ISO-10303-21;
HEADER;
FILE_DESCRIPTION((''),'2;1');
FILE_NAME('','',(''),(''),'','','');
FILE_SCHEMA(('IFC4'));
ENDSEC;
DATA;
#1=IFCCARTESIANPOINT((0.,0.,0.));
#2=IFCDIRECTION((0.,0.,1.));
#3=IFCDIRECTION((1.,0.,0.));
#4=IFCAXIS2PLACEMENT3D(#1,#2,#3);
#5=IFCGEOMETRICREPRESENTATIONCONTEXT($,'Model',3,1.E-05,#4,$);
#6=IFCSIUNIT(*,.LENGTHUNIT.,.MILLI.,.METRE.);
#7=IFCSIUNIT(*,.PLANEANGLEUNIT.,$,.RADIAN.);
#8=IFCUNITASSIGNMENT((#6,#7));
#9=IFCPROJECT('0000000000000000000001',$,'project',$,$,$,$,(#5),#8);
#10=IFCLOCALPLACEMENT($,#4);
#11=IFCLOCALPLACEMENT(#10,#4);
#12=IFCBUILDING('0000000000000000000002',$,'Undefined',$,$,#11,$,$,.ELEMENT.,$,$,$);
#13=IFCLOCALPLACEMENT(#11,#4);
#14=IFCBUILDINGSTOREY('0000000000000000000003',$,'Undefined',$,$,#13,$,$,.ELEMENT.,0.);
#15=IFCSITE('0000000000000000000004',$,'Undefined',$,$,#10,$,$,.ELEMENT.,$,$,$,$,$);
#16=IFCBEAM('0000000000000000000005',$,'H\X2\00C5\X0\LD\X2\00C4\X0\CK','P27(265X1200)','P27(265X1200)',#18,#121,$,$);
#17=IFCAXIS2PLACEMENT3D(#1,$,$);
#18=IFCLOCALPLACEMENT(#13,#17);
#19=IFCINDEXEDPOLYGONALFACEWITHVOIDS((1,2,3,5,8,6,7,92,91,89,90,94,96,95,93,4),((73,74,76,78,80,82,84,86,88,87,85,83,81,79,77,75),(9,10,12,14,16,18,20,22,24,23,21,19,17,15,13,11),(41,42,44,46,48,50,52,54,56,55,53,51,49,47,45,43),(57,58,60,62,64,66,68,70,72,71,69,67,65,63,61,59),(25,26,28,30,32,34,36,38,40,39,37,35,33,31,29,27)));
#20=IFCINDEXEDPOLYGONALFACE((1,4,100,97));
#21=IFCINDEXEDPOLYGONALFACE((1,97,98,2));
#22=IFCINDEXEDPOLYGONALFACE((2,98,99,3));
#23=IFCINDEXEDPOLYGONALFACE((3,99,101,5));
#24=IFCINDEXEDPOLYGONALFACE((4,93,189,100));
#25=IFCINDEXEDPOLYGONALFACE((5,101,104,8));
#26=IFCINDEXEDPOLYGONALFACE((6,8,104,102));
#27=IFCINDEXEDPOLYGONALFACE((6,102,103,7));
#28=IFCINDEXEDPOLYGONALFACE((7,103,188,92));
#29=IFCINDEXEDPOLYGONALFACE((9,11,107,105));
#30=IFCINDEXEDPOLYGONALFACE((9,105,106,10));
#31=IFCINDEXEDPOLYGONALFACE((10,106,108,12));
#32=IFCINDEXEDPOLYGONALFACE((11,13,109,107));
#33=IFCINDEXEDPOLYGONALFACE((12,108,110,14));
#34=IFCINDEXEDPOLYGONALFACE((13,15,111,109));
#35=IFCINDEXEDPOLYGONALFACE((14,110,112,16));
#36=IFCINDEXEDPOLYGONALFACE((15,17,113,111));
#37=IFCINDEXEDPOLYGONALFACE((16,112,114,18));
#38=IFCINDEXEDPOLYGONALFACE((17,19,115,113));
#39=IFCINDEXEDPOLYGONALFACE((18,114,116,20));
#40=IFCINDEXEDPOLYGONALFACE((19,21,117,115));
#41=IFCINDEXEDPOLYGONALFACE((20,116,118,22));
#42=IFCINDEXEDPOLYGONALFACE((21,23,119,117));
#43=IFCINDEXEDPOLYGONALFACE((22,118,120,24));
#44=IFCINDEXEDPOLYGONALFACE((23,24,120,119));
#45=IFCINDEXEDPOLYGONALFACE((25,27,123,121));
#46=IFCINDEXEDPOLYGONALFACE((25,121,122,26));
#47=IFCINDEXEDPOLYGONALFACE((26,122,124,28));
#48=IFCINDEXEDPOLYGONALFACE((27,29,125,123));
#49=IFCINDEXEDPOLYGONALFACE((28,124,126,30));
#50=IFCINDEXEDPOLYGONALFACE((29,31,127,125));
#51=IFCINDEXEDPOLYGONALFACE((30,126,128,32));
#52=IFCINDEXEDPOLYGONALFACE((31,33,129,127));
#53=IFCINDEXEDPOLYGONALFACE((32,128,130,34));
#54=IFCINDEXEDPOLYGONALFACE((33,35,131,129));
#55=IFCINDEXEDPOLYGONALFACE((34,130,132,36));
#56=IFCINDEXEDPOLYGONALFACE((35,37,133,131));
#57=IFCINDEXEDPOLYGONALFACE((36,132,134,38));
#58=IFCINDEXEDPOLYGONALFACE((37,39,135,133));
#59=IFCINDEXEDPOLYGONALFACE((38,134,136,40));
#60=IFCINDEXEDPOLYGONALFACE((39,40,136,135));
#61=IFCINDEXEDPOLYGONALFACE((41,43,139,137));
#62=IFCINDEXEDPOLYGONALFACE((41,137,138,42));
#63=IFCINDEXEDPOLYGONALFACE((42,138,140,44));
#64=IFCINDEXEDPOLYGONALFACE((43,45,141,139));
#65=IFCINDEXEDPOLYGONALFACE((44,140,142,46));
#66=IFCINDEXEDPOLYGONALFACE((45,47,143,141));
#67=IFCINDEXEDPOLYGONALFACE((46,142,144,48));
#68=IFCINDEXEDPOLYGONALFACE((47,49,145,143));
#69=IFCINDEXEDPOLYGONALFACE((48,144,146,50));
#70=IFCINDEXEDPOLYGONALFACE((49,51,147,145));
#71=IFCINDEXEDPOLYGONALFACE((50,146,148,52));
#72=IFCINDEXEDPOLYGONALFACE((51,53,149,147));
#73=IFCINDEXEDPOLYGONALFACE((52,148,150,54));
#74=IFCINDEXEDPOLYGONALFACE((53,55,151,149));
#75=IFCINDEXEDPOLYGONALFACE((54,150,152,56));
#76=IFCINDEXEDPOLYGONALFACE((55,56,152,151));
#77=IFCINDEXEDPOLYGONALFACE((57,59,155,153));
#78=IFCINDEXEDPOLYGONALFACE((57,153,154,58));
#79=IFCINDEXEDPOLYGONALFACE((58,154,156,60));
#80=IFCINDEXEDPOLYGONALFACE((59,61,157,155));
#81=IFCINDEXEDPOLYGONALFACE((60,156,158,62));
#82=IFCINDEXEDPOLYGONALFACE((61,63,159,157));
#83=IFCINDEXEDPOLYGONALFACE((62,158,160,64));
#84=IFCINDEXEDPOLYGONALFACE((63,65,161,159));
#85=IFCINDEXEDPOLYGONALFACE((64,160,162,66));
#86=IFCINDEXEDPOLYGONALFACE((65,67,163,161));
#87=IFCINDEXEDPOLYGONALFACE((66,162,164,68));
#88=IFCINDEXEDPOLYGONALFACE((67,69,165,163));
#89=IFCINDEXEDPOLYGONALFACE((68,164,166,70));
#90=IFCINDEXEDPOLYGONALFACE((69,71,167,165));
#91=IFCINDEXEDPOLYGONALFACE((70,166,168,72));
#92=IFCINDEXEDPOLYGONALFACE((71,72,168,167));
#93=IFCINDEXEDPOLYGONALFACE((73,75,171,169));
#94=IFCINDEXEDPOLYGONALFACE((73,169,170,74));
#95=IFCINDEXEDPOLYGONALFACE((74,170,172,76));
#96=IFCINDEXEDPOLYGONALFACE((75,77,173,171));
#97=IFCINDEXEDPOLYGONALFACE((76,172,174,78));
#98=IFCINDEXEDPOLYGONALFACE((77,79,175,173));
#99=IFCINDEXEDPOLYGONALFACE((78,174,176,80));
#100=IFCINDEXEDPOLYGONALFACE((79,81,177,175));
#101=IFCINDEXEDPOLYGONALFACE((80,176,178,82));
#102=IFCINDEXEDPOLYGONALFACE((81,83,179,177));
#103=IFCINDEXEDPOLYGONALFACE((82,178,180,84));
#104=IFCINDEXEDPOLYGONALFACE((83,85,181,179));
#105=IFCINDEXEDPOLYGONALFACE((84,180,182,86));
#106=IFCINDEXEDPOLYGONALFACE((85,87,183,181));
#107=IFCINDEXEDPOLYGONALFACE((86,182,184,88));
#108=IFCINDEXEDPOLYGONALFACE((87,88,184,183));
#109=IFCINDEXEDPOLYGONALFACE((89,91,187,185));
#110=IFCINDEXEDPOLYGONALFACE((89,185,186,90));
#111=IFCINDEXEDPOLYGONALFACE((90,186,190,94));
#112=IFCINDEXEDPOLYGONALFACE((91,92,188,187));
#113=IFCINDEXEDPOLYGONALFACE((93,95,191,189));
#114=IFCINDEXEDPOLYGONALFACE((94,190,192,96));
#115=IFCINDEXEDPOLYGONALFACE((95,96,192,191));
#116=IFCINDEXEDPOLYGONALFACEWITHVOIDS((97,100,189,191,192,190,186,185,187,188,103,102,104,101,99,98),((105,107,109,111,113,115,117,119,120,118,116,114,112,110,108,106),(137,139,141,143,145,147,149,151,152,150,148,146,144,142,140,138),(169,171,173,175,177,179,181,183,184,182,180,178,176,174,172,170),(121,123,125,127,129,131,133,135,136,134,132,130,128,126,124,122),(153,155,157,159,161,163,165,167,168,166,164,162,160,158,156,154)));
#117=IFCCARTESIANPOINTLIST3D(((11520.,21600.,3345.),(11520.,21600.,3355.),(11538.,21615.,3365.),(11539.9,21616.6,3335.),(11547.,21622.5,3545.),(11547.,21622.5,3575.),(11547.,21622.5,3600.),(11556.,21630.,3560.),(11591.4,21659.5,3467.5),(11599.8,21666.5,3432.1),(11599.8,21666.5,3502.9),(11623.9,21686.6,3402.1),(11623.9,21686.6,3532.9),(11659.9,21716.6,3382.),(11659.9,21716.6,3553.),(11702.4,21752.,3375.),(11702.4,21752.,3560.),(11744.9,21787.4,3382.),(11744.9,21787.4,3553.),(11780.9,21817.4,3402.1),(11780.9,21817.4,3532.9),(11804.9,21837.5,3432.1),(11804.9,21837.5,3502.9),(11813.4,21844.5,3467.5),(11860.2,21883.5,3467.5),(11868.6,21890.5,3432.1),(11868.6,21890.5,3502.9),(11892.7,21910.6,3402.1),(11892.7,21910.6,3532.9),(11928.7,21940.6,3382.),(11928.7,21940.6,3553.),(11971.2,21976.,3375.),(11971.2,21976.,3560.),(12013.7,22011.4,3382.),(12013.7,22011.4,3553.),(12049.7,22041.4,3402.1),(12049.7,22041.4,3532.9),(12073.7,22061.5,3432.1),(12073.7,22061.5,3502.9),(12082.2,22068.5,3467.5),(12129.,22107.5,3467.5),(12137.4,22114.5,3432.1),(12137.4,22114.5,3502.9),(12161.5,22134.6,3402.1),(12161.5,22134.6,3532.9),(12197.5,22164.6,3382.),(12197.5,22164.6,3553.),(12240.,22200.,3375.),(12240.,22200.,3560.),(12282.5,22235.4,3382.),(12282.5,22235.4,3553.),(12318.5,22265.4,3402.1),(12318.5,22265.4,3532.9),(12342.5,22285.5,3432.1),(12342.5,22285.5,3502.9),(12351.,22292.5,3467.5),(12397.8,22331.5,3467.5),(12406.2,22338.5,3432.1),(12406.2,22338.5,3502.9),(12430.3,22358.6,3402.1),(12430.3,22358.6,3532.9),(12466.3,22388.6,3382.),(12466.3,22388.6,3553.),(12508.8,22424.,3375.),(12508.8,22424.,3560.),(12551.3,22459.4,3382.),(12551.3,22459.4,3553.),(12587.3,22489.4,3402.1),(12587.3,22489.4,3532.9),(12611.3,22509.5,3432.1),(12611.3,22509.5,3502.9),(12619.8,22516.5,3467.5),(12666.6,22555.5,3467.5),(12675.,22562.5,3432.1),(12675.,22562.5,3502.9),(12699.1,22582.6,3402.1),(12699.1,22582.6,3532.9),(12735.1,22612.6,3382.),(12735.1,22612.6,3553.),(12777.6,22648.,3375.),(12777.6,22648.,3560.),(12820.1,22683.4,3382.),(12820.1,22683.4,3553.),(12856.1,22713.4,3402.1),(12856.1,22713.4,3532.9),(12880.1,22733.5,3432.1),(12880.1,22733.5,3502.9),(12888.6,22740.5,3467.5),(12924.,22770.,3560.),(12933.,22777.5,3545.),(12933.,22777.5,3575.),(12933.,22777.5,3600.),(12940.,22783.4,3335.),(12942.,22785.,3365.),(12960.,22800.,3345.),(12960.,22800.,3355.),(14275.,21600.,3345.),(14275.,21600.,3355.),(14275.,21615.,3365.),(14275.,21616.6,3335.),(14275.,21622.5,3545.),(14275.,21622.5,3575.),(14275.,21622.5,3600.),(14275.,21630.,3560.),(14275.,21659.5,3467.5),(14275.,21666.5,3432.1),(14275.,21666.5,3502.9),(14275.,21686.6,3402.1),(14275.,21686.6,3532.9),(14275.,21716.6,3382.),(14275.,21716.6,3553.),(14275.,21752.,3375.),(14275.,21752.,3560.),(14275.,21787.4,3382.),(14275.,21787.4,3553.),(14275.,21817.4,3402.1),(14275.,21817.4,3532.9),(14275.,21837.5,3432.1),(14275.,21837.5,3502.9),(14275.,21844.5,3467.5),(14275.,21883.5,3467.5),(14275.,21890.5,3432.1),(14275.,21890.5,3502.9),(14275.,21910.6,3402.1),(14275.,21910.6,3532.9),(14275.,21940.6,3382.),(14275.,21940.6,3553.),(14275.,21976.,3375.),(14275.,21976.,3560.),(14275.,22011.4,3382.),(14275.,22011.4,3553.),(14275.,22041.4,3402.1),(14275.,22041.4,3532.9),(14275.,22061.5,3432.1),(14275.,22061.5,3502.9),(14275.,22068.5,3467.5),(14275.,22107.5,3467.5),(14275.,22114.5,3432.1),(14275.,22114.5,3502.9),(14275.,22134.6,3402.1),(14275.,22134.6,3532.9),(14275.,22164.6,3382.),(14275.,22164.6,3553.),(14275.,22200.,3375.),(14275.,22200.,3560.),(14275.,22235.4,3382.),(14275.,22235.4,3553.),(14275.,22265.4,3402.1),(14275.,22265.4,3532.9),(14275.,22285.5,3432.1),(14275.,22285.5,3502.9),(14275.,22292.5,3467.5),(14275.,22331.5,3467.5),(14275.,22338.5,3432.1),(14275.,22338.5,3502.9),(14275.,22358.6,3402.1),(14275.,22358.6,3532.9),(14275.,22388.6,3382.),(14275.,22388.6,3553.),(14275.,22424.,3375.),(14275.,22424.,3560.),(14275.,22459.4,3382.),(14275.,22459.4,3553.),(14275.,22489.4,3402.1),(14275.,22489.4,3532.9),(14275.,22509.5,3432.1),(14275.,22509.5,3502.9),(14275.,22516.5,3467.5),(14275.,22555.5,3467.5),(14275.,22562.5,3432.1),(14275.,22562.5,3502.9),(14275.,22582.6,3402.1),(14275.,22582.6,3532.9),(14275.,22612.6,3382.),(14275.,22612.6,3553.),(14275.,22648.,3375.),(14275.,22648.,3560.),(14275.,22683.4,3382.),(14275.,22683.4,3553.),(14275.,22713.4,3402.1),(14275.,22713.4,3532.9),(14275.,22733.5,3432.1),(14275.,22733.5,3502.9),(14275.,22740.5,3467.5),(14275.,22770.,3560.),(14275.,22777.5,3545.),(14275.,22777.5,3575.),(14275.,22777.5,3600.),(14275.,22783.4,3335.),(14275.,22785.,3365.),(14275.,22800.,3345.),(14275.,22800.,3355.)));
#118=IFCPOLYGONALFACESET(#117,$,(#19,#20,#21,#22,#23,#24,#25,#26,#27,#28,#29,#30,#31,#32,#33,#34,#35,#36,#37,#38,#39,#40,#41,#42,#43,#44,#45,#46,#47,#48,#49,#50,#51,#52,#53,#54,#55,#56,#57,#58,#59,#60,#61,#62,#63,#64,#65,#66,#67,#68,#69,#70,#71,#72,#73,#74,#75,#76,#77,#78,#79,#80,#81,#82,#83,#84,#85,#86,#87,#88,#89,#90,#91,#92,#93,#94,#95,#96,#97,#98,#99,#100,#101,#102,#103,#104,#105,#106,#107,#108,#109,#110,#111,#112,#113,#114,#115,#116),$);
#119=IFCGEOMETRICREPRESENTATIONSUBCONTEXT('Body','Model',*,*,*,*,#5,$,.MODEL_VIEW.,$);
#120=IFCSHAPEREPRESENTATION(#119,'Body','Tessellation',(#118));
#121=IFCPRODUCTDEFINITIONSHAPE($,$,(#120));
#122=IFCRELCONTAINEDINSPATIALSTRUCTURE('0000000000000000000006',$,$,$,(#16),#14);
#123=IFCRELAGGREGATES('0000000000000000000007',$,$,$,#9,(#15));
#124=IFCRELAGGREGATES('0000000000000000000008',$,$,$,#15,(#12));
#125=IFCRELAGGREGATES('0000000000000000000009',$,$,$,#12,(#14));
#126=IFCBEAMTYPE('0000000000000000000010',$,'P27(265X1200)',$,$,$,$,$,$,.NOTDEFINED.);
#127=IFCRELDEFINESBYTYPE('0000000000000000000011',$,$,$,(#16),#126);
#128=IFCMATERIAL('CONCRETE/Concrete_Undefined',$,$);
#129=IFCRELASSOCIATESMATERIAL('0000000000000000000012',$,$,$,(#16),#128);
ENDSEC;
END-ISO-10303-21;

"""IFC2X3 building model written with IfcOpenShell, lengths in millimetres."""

from ifc_helpers import new_model, si_unit, frame, origin_with_axes, place, context, subcontext, project, spatial, polyline, outline, extrude, clip, halfspace, material, type_object, element, save


model = new_model("IFC2X3")

# Units and contexts
model_context = context("Model", 3, precision=1e-05, world=origin_with_axes())
body_context = subcontext(model_context, "Body", "Model", "MODEL_VIEW")
ifc_project = project(units=[si_unit("LENGTHUNIT", "METRE", prefix="MILLI"), si_unit("PLANEANGLEUNIT", "RADIAN")], contexts=[model_context])

# Site, building, storey
site_placement = place(None, origin_with_axes())
site = spatial("IfcSite", under=ifc_project, at=site_placement, Name="Undefined", CompositionType="ELEMENT")
building_placement = place(site_placement, origin_with_axes())
building = spatial("IfcBuilding", under=site, at=building_placement, Name="Undefined", CompositionType="ELEMENT")
storey_placement = place(building_placement, origin_with_axes())
storey = spatial("IfcBuildingStorey", under=building, at=storey_placement, Name="Undefined", CompositionType="ELEMENT", Elevation=0.0)

# Beam
ifc_material_1 = material(Name="CONCRETE/Concrete_Undefined")
beam_type_1 = type_object("IfcBeamType", Name="P27(265X1200)", PredefinedType="NOTDEFINED")
beam_1_placement = place(storey_placement, frame((11520.0, 22200.0, 3467.5), z_axis=(0.0, 0.0, 1.0), x_axis=(1.0, 0.0, 0.0)))
element("IfcBeam", 1, at=beam_1_placement, inside=storey, type_object=beam_type_1, material=ifc_material_1, Name="HÅLDÄCK", Description="P27(265X1200)", ObjectType="P27(265X1200)", context=body_context, shape_type="Clipping", body=[
    clip(extrude(outline(polyline([(-583.4, -132.5), (-600.0, -122.5), (-600.0, -112.5), (-585.0, -102.5), (-577.5, 77.5), (-570.0, 92.5), (-577.5, 107.5), (-577.5, 132.5), (577.5, 132.5), (577.5, 107.5), (570.0, 92.5), (577.5, 77.5), (585.0, -102.5), (600.0, -112.5), (600.0, -122.5), (583.4, -132.5), (-583.4, -132.5)]), holes=[polyline([(-513.4, 65.4), (-533.5, 35.4), (-540.5, 0.0), (-533.5, -35.4), (-513.4, -65.4), (-483.4, -85.5), (-448.0, -92.5), (-412.6, -85.5), (-382.6, -65.4), (-362.5, -35.4), (-355.5, 0.0), (-362.5, 35.4), (-382.6, 65.4), (-412.6, 85.5), (-448.0, 92.5), (-483.4, 85.5), (-513.4, 65.4)]), polyline([(-289.4, 65.4), (-309.5, 35.4), (-316.5, 0.0), (-309.5, -35.4), (-289.4, -65.4), (-259.4, -85.5), (-224.0, -92.5), (-188.6, -85.5), (-158.6, -65.4), (-138.5, -35.4), (-131.5, 0.0), (-138.5, 35.4), (-158.6, 65.4), (-188.6, 85.5), (-224.0, 92.5), (-259.4, 85.5), (-289.4, 65.4)]), polyline([(-65.4, 65.4), (-85.5, 35.4), (-92.5, 0.0), (-85.5, -35.4), (-65.4, -65.4), (-35.4, -85.5), (0.0, -92.5), (35.4, -85.5), (65.4, -65.4), (85.5, -35.4), (92.5, 0.0), (85.5, 35.4), (65.4, 65.4), (35.4, 85.5), (0.0, 92.5), (-35.4, 85.5), (-65.4, 65.4)]), polyline([(158.6, 65.4), (138.5, 35.4), (131.5, 0.0), (138.5, -35.4), (158.6, -65.4), (188.6, -85.5), (224.0, -92.5), (259.4, -85.5), (289.4, -65.4), (309.5, -35.4), (316.5, 0.0), (309.5, 35.4), (289.4, 65.4), (259.4, 85.5), (224.0, 92.5), (188.6, 85.5), (158.6, 65.4)]), polyline([(382.6, 65.4), (362.5, 35.4), (355.5, 0.0), (362.5, -35.4), (382.6, -65.4), (412.6, -85.5), (448.0, -92.5), (483.4, -85.5), (513.4, -65.4), (533.5, -35.4), (540.5, 0.0), (533.5, 35.4), (513.4, 65.4), (483.4, 85.5), (448.0, 92.5), (412.6, 85.5), (382.6, 65.4)])]), frame((2755.0, 0.0, 0.0), z_axis=(-1.0, 0.0, 0.0), x_axis=(0.0, -1.0, 0.0)), (0.0, 0.0, 1.0), 2755.0), halfspace(frame((1440.0, 600.0, -132.5), z_axis=(-0.640184, 0.768221, 0.0), x_axis=(0.0, 0.0, 1.0)), False)),
])

save(model, "model.ifc")
